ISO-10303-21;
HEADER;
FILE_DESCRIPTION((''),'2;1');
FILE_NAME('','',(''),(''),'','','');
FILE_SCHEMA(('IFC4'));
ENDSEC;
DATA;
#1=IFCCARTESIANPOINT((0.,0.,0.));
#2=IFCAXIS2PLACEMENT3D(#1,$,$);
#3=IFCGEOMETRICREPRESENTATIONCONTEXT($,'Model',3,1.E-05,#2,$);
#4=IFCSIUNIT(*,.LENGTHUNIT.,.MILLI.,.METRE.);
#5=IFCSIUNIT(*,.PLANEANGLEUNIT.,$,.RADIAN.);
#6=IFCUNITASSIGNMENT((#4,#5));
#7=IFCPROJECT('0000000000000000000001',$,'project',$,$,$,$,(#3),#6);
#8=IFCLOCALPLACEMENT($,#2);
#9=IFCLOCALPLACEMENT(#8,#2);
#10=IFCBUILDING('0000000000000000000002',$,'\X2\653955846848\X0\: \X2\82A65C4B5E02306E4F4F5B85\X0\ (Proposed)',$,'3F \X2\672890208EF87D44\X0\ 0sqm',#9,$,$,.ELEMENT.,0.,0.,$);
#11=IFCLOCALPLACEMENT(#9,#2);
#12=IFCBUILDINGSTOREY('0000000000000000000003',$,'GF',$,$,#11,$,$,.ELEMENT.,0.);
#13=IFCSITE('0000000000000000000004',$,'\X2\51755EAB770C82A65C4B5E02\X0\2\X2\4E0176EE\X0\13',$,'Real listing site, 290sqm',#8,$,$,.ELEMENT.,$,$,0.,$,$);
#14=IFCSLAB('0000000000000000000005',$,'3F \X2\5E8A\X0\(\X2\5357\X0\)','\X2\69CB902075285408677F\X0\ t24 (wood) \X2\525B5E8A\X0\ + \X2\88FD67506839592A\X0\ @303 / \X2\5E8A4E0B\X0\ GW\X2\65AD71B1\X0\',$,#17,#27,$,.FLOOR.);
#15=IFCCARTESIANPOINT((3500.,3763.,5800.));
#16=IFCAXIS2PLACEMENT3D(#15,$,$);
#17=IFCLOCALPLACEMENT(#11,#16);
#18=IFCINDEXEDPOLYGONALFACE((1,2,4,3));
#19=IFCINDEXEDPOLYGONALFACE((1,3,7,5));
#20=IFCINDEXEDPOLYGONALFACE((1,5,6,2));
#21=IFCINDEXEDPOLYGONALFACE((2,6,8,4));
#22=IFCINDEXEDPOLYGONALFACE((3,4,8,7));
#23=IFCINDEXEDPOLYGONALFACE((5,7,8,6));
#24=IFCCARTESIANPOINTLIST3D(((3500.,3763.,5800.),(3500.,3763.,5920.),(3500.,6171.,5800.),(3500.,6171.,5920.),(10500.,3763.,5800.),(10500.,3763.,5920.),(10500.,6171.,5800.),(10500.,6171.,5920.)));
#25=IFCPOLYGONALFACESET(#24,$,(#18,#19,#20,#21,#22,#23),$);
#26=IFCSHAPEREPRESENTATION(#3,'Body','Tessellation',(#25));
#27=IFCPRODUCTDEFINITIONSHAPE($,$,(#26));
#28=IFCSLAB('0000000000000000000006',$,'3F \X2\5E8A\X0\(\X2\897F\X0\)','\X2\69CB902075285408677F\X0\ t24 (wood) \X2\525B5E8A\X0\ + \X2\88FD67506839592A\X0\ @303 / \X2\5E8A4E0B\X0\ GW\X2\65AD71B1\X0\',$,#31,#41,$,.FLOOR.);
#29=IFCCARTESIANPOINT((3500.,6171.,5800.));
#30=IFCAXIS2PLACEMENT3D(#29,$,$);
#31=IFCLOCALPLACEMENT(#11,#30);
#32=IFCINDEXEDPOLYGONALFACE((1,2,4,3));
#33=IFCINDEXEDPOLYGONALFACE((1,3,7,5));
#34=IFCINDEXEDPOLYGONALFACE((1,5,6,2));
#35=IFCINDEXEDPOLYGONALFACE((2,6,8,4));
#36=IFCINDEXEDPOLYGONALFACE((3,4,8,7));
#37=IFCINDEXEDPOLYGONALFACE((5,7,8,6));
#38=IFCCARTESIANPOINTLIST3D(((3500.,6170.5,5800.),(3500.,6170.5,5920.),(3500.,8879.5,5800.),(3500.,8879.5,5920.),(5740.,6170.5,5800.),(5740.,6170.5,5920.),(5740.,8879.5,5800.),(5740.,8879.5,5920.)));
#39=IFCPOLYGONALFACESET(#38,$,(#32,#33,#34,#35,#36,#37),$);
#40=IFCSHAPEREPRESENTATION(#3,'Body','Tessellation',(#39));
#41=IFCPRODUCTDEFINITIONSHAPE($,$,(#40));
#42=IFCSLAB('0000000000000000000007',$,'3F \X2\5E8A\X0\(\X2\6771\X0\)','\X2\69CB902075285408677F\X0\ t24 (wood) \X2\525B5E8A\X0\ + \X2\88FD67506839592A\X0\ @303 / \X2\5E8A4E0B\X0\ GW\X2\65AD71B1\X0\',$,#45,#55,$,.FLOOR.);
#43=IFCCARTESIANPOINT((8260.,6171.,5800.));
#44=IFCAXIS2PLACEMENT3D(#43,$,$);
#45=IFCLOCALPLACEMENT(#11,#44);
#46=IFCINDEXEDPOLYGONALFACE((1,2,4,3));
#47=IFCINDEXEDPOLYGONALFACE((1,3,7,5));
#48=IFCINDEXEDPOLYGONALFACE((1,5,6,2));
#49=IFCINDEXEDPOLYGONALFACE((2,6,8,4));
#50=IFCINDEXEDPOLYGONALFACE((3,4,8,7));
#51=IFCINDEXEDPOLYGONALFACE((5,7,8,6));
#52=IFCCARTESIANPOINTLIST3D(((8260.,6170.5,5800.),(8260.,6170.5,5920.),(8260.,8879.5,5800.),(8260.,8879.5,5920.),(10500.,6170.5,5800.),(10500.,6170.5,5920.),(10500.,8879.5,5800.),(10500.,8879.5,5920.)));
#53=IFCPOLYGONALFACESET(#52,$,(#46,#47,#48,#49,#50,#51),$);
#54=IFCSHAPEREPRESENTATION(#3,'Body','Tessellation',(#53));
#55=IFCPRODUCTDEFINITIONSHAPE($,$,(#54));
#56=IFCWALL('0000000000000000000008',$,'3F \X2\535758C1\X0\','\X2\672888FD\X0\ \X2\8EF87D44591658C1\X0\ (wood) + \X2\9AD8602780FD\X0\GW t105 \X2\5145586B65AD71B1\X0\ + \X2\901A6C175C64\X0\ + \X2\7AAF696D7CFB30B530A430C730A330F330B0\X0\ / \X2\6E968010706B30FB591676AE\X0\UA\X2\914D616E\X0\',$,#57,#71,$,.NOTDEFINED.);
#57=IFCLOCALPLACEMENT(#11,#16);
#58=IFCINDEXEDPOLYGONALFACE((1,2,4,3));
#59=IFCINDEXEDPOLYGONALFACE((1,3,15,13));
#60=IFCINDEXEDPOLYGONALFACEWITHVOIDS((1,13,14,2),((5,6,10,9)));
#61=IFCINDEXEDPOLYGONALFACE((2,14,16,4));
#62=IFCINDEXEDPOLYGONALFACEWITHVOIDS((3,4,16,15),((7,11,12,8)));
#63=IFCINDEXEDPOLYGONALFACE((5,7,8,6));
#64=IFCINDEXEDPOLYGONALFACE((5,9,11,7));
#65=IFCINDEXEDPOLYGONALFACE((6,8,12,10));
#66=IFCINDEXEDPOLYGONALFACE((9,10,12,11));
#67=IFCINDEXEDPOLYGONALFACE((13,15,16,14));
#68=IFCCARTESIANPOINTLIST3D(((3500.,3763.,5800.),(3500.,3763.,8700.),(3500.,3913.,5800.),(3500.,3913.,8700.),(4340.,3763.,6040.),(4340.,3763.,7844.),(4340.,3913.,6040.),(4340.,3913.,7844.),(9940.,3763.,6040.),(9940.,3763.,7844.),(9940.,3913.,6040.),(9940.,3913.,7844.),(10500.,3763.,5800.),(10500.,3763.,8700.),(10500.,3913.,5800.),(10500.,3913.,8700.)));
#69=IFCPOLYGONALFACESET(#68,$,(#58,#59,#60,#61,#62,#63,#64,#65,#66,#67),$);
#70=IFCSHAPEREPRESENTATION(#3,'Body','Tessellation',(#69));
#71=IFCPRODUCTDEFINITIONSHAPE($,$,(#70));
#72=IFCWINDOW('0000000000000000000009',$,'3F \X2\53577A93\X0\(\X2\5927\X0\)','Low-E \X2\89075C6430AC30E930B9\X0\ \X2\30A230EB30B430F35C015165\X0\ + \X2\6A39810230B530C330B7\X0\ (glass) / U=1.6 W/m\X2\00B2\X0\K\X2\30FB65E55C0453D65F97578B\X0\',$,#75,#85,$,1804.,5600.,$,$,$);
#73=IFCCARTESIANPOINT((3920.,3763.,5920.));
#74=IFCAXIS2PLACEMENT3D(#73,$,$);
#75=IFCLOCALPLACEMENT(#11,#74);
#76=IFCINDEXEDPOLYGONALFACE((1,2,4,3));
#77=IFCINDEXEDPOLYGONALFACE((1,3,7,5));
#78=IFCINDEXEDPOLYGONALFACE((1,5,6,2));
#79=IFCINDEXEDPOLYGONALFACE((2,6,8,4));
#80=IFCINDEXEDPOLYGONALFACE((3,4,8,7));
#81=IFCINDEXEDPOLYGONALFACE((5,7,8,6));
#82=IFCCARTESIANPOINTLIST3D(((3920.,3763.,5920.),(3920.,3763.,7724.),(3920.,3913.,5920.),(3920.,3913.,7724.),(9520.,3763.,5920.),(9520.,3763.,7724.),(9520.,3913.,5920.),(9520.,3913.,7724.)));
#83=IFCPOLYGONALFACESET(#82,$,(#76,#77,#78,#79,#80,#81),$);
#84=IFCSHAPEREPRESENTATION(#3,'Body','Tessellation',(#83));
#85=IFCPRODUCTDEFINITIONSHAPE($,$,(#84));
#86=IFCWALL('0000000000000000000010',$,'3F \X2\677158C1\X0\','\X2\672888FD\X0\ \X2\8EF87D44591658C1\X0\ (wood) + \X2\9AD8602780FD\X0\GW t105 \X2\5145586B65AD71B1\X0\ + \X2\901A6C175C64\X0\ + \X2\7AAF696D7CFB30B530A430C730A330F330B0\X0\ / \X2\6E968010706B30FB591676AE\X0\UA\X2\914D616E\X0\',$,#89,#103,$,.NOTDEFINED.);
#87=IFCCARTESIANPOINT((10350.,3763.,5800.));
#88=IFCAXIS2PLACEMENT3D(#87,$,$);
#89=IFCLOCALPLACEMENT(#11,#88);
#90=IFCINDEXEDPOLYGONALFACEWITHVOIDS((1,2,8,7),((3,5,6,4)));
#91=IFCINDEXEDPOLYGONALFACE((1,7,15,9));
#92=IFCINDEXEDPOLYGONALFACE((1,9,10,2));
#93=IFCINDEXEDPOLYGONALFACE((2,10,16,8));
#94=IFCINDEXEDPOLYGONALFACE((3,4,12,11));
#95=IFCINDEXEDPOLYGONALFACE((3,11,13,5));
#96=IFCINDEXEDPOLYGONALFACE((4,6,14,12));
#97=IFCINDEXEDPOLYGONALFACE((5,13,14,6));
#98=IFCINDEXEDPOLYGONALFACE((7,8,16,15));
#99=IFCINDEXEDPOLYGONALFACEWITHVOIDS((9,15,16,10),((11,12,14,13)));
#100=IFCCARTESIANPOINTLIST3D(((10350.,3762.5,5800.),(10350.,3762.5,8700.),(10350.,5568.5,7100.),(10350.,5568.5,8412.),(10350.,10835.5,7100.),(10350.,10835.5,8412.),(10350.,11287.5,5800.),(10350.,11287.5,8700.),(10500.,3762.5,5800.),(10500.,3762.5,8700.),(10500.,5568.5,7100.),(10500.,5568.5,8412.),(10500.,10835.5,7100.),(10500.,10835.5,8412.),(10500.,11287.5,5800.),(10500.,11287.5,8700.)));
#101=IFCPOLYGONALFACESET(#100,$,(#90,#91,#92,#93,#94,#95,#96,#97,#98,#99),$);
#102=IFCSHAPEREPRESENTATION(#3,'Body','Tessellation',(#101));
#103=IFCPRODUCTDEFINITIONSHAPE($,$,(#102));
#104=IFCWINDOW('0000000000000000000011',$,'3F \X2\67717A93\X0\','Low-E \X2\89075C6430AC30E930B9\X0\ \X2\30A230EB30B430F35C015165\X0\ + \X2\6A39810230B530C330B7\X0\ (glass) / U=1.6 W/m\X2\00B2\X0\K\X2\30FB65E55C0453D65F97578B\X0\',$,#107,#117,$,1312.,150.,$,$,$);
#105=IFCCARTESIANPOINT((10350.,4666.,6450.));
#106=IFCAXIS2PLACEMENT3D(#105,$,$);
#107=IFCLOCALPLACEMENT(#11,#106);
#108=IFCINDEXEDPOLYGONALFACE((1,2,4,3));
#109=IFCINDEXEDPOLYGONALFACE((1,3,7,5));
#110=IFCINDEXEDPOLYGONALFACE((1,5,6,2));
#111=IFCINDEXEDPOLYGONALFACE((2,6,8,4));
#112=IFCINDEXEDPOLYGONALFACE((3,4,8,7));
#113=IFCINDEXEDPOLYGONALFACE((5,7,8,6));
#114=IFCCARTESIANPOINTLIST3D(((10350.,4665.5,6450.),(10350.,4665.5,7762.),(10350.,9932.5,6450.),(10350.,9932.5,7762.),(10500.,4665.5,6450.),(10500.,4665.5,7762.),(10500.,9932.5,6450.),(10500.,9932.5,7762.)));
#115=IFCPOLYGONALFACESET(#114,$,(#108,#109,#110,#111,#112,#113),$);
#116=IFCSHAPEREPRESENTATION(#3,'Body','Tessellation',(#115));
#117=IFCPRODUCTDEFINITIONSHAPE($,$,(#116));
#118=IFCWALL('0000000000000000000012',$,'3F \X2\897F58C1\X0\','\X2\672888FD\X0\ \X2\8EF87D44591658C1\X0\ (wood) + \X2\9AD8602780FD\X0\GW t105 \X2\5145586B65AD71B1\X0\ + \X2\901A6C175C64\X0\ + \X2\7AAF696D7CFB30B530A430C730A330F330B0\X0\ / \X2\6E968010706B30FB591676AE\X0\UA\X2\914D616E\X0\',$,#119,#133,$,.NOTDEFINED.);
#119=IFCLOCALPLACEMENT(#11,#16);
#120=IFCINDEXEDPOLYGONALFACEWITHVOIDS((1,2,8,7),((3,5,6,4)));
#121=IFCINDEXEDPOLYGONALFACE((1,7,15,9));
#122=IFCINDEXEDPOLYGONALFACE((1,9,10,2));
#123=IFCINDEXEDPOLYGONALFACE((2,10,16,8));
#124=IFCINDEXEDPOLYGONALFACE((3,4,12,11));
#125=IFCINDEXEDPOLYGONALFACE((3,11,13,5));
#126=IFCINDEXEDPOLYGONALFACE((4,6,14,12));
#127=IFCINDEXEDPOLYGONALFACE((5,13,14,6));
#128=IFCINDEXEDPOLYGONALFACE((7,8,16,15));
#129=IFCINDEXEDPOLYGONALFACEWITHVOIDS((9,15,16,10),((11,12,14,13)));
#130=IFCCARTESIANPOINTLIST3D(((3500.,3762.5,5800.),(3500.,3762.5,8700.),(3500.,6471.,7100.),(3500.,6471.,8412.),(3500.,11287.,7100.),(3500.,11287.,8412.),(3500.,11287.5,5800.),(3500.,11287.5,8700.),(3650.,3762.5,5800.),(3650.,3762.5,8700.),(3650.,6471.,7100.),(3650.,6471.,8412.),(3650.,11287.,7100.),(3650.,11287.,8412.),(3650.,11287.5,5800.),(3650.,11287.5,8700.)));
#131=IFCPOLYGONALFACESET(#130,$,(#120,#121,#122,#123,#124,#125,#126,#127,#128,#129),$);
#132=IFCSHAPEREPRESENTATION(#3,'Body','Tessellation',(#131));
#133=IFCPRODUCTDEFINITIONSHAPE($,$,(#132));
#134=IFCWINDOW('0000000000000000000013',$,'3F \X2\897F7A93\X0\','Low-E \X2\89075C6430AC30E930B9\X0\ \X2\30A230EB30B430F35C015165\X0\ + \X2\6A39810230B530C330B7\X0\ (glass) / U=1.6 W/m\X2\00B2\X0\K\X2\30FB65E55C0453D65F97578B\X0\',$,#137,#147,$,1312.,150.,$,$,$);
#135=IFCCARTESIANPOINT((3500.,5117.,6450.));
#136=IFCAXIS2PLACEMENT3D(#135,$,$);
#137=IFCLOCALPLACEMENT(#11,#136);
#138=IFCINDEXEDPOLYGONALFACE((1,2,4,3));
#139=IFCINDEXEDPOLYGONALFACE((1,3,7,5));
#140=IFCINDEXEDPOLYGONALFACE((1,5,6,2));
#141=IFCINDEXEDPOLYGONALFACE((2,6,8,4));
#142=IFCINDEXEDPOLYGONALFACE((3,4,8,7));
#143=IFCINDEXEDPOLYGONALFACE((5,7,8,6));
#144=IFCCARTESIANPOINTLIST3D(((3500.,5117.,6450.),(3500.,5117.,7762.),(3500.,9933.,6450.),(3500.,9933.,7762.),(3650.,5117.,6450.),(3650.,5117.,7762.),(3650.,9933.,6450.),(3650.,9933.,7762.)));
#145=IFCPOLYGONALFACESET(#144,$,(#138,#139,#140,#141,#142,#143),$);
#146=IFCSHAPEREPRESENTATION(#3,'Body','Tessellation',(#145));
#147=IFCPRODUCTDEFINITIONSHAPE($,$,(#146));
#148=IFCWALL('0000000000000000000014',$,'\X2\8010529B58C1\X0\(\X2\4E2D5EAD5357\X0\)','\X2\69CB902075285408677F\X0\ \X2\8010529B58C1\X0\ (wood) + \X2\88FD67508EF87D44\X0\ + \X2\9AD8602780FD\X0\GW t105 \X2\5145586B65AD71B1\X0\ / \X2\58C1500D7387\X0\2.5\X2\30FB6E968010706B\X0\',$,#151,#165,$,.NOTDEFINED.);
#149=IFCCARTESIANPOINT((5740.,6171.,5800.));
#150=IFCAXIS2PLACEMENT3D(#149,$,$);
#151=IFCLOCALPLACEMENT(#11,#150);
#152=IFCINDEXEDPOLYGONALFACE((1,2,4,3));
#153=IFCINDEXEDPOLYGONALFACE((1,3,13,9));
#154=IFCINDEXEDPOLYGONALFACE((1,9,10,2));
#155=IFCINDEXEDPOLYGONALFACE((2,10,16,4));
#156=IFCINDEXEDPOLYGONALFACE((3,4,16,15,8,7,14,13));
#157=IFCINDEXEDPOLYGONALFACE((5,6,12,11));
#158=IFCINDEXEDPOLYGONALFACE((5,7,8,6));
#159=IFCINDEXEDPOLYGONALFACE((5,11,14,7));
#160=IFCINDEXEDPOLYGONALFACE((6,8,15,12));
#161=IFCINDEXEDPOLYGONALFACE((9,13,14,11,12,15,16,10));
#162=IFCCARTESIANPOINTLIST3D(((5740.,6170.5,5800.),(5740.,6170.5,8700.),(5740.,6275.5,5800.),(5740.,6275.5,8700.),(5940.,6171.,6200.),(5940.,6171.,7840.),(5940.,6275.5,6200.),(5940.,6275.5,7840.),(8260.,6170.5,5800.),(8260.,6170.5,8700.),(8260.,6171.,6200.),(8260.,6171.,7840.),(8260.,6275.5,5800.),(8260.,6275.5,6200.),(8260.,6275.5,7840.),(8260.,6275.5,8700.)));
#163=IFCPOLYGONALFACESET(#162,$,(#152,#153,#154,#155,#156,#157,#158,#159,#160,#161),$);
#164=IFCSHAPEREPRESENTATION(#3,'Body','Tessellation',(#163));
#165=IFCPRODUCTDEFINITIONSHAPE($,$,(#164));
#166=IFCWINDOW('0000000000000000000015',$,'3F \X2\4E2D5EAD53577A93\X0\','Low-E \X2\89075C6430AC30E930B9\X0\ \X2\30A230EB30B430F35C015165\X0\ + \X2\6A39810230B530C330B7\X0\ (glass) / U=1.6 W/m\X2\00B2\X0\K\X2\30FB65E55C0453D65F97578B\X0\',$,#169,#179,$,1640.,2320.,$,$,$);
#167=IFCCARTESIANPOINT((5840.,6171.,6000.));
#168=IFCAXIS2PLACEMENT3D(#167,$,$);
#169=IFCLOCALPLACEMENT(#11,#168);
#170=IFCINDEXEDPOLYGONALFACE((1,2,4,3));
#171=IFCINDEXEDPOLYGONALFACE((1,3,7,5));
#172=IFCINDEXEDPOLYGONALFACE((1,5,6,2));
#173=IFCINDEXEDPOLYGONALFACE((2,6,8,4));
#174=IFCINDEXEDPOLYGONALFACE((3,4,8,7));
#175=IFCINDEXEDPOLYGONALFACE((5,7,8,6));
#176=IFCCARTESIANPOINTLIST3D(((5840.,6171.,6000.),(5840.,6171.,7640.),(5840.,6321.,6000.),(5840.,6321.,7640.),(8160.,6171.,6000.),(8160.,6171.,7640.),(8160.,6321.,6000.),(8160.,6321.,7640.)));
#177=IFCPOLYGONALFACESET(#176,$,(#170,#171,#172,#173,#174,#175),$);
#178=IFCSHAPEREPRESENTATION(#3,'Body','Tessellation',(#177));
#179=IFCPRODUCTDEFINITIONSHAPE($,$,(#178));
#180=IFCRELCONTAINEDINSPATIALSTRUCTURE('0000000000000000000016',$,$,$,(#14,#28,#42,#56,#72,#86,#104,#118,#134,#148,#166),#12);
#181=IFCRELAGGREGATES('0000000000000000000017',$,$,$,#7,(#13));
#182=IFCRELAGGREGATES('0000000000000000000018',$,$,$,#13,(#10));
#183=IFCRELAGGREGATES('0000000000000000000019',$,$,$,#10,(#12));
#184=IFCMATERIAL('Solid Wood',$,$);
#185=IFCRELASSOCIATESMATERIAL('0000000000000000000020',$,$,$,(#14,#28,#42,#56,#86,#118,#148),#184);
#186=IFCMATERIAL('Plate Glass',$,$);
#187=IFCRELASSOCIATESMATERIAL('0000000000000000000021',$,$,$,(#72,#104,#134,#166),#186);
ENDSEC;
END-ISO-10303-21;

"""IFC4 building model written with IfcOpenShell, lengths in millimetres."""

from ifc_helpers import new_model, si_unit, frame, frame_2d, origin, place, context, project, spatial, rectangle, extrude, material, element, fill, save


model = new_model("IFC4")

# Units and contexts
model_context = context("Model", 3, precision=1e-05, world=origin())
ifc_project = project(units=[si_unit("LENGTHUNIT", "METRE", prefix="MILLI"), si_unit("PLANEANGLEUNIT", "RADIAN")], contexts=[model_context])

# Site, building, storey
site_placement = place(None, origin())
site = spatial("IfcSite", under=ifc_project, at=site_placement, Name="兵庫県芦屋市2丁目13", ObjectType="Real listing site, 290sqm", CompositionType="ELEMENT", RefElevation=0.0)
building_placement = place(site_placement, origin())
building = spatial("IfcBuilding", under=site, at=building_placement, Name="改善案: 芦屋市の住宅 (Proposed)", ObjectType="3F 木造軸組 0sqm", CompositionType="ELEMENT", ElevationOfRefHeight=0.0, ElevationOfTerrain=0.0)
storey_placement = place(building_placement, origin())
storey = spatial("IfcBuildingStorey", under=building, at=storey_placement, Name="GF", CompositionType="ELEMENT", Elevation=0.0)

# Slabs
ifc_material_1 = material(Name="Solid Wood")
slab_1_placement = place(storey_placement, frame((3500.0, 3763.0, 5800.0)))
element("IfcSlab", 1, at=slab_1_placement, inside=storey, material=ifc_material_1, Name="3F 床(南)", Description="構造用合板 t24 (wood) 剛床 + 製材根太 @303 / 床下 GW断熱", PredefinedType="FLOOR", context=model_context, shape_type="SweptSolid", body=[
    extrude(rectangle(XDim=7000.0, YDim=2408.0, at=frame_2d((3500.0, 1204.0))), frame((3500.0, 3763.0, 5800.0)), (0.0, 0.0, 1.0), 120.0),
])
slab_2_placement = place(storey_placement, frame((3500.0, 6171.0, 5800.0)))
element("IfcSlab", 2, at=slab_2_placement, inside=storey, material=ifc_material_1, Name="3F 床(西)", Description="構造用合板 t24 (wood) 剛床 + 製材根太 @303 / 床下 GW断熱", PredefinedType="FLOOR", context=model_context, shape_type="SweptSolid", body=[
    extrude(rectangle(XDim=2240.0, YDim=2709.0, at=frame_2d((1120.0, 1354.0))), frame((3500.0, 6171.0, 5800.0)), (0.0, 0.0, 1.0), 120.0),
])
slab_3_placement = place(storey_placement, frame((8260.0, 6171.0, 5800.0)))
element("IfcSlab", 3, at=slab_3_placement, inside=storey, material=ifc_material_1, Name="3F 床(東)", Description="構造用合板 t24 (wood) 剛床 + 製材根太 @303 / 床下 GW断熱", PredefinedType="FLOOR", context=model_context, shape_type="SweptSolid", body=[
    extrude(rectangle(XDim=2240.0, YDim=2709.0, at=frame_2d((1120.0, 1354.0))), frame((8260.0, 6171.0, 5800.0)), (0.0, 0.0, 1.0), 120.0),
])

# Walls, openings, windows
wall_1_placement = place(storey_placement, frame((3500.0, 3763.0, 5800.0)))
wall_1 = element("IfcWall", 4, at=wall_1_placement, inside=storey, material=ifc_material_1, Name="3F 南壁", Description="木製 軸組外壁 (wood) + 高性能GW t105 充填断熱 + 通気層 + 窯業系サイディング / 準耐火・外皮UA配慮", PredefinedType="NOTDEFINED", context=model_context, shape_type="SweptSolid", body=[
    extrude(rectangle(XDim=7000.0, YDim=150.0, at=frame_2d((3500.0, 75.0))), frame((3500.0, 3763.0, 5800.0)), (0.0, 0.0, 1.0), 2900.0),
])
opening_1_placement = place(storey_placement, frame((3920.0, 3763.0, 5920.0)))
opening_1 = element("IfcOpeningElement", 5, at=opening_1_placement, cuts=wall_1, PredefinedType="NOTDEFINED", context=model_context, shape_type="SweptSolid", body=[
    extrude(rectangle(XDim=5600.0, YDim=150.0, at=frame_2d((2800.0, 75.0))), frame((3920.0, 3763.0, 5920.0)), (0.0, 0.0, 1.0), 1804.0),
])
ifc_material_2 = material(Name="Plate Glass")
window_1_placement = place(storey_placement, frame((3920.0, 3763.0, 5920.0)))
window_1 = element("IfcWindow", 6, at=window_1_placement, inside=storey, material=ifc_material_2, Name="3F 南窓(大)", Description="Low-E 複層ガラス アルゴン封入 + 樹脂サッシ (glass) / U=1.6 W/m²K・日射取得型", OverallHeight=1804.0, OverallWidth=5600.0, context=model_context, shape_type="SweptSolid", body=[
    extrude(rectangle(XDim=5600.0, YDim=150.0, at=frame_2d((2800.0, 75.0))), frame((3920.0, 3763.0, 5920.0)), (0.0, 0.0, 1.0), 1804.0),
])
fill(opening_1, window_1)
wall_2_placement = place(storey_placement, frame((10350.0, 3763.0, 5800.0)))
wall_2 = element("IfcWall", 7, at=wall_2_placement, inside=storey, material=ifc_material_1, Name="3F 東壁", Description="木製 軸組外壁 (wood) + 高性能GW t105 充填断熱 + 通気層 + 窯業系サイディング / 準耐火・外皮UA配慮", PredefinedType="NOTDEFINED", context=model_context, shape_type="SweptSolid", body=[
    extrude(rectangle(XDim=150.0, YDim=7525.0, at=frame_2d((75.0, 3762.0))), frame((10350.0, 3763.0, 5800.0)), (0.0, 0.0, 1.0), 2900.0),
])
opening_2_placement = place(storey_placement, frame((10350.0, 4666.0, 6450.0)))
opening_2 = element("IfcOpeningElement", 8, at=opening_2_placement, cuts=wall_2, PredefinedType="NOTDEFINED", context=model_context, shape_type="SweptSolid", body=[
    extrude(rectangle(XDim=150.0, YDim=5267.0, at=frame_2d((75.0, 2633.0))), frame((10350.0, 4666.0, 6450.0)), (0.0, 0.0, 1.0), 1312.0),
])
window_2_placement = place(storey_placement, frame((10350.0, 4666.0, 6450.0)))
window_2 = element("IfcWindow", 9, at=window_2_placement, inside=storey, material=ifc_material_2, Name="3F 東窓", Description="Low-E 複層ガラス アルゴン封入 + 樹脂サッシ (glass) / U=1.6 W/m²K・日射取得型", OverallHeight=1312.0, OverallWidth=150.0, context=model_context, shape_type="SweptSolid", body=[
    extrude(rectangle(XDim=150.0, YDim=5267.0, at=frame_2d((75.0, 2633.0))), frame((10350.0, 4666.0, 6450.0)), (0.0, 0.0, 1.0), 1312.0),
])
fill(opening_2, window_2)
wall_3_placement = place(storey_placement, frame((3500.0, 3763.0, 5800.0)))
wall_3 = element("IfcWall", 10, at=wall_3_placement, inside=storey, material=ifc_material_1, Name="3F 西壁", Description="木製 軸組外壁 (wood) + 高性能GW t105 充填断熱 + 通気層 + 窯業系サイディング / 準耐火・外皮UA配慮", PredefinedType="NOTDEFINED", context=model_context, shape_type="SweptSolid", body=[
    extrude(rectangle(XDim=150.0, YDim=7525.0, at=frame_2d((75.0, 3762.0))), frame((3500.0, 3763.0, 5800.0)), (0.0, 0.0, 1.0), 2900.0),
])
opening_3_placement = place(storey_placement, frame((3500.0, 5117.0, 6450.0)))
opening_3 = element("IfcOpeningElement", 11, at=opening_3_placement, cuts=wall_3, PredefinedType="NOTDEFINED", context=model_context, shape_type="SweptSolid", body=[
    extrude(rectangle(XDim=150.0, YDim=4816.0, at=frame_2d((75.0, 2408.0))), frame((3500.0, 5117.0, 6450.0)), (0.0, 0.0, 1.0), 1312.0),
])
window_3_placement = place(storey_placement, frame((3500.0, 5117.0, 6450.0)))
window_3 = element("IfcWindow", 12, at=window_3_placement, inside=storey, material=ifc_material_2, Name="3F 西窓", Description="Low-E 複層ガラス アルゴン封入 + 樹脂サッシ (glass) / U=1.6 W/m²K・日射取得型", OverallHeight=1312.0, OverallWidth=150.0, context=model_context, shape_type="SweptSolid", body=[
    extrude(rectangle(XDim=150.0, YDim=4816.0, at=frame_2d((75.0, 2408.0))), frame((3500.0, 5117.0, 6450.0)), (0.0, 0.0, 1.0), 1312.0),
])
fill(opening_3, window_3)
wall_4_placement = place(storey_placement, frame((5740.0, 6171.0, 5800.0)))
wall_4 = element("IfcWall", 13, at=wall_4_placement, inside=storey, material=ifc_material_1, Name="耐力壁(中庭南)", Description="構造用合板 耐力壁 (wood) + 製材軸組 + 高性能GW t105 充填断熱 / 壁倍率2.5・準耐火", PredefinedType="NOTDEFINED", context=model_context, shape_type="SweptSolid", body=[
    extrude(rectangle(XDim=2520.0, YDim=105.0, at=frame_2d((1260.0, 52.0))), frame((5740.0, 6171.0, 5800.0)), (0.0, 0.0, 1.0), 2900.0),
])
opening_4_placement = place(storey_placement, frame((5840.0, 6171.0, 6000.0)))
opening_4 = element("IfcOpeningElement", 14, at=opening_4_placement, cuts=wall_4, PredefinedType="NOTDEFINED", context=model_context, shape_type="SweptSolid", body=[
    extrude(rectangle(XDim=2320.0, YDim=150.0, at=frame_2d((1160.0, 75.0))), frame((5840.0, 6171.0, 6000.0)), (0.0, 0.0, 1.0), 1640.0),
])
window_4_placement = place(storey_placement, frame((5840.0, 6171.0, 6000.0)))
window_4 = element("IfcWindow", 15, at=window_4_placement, inside=storey, material=ifc_material_2, Name="3F 中庭南窓", Description="Low-E 複層ガラス アルゴン封入 + 樹脂サッシ (glass) / U=1.6 W/m²K・日射取得型", OverallHeight=1640.0, OverallWidth=2320.0, context=model_context, shape_type="SweptSolid", body=[
    extrude(rectangle(XDim=2320.0, YDim=150.0, at=frame_2d((1160.0, 75.0))), frame((5840.0, 6171.0, 6000.0)), (0.0, 0.0, 1.0), 1640.0),
])
fill(opening_4, window_4)

save(model, "model.ifc")
